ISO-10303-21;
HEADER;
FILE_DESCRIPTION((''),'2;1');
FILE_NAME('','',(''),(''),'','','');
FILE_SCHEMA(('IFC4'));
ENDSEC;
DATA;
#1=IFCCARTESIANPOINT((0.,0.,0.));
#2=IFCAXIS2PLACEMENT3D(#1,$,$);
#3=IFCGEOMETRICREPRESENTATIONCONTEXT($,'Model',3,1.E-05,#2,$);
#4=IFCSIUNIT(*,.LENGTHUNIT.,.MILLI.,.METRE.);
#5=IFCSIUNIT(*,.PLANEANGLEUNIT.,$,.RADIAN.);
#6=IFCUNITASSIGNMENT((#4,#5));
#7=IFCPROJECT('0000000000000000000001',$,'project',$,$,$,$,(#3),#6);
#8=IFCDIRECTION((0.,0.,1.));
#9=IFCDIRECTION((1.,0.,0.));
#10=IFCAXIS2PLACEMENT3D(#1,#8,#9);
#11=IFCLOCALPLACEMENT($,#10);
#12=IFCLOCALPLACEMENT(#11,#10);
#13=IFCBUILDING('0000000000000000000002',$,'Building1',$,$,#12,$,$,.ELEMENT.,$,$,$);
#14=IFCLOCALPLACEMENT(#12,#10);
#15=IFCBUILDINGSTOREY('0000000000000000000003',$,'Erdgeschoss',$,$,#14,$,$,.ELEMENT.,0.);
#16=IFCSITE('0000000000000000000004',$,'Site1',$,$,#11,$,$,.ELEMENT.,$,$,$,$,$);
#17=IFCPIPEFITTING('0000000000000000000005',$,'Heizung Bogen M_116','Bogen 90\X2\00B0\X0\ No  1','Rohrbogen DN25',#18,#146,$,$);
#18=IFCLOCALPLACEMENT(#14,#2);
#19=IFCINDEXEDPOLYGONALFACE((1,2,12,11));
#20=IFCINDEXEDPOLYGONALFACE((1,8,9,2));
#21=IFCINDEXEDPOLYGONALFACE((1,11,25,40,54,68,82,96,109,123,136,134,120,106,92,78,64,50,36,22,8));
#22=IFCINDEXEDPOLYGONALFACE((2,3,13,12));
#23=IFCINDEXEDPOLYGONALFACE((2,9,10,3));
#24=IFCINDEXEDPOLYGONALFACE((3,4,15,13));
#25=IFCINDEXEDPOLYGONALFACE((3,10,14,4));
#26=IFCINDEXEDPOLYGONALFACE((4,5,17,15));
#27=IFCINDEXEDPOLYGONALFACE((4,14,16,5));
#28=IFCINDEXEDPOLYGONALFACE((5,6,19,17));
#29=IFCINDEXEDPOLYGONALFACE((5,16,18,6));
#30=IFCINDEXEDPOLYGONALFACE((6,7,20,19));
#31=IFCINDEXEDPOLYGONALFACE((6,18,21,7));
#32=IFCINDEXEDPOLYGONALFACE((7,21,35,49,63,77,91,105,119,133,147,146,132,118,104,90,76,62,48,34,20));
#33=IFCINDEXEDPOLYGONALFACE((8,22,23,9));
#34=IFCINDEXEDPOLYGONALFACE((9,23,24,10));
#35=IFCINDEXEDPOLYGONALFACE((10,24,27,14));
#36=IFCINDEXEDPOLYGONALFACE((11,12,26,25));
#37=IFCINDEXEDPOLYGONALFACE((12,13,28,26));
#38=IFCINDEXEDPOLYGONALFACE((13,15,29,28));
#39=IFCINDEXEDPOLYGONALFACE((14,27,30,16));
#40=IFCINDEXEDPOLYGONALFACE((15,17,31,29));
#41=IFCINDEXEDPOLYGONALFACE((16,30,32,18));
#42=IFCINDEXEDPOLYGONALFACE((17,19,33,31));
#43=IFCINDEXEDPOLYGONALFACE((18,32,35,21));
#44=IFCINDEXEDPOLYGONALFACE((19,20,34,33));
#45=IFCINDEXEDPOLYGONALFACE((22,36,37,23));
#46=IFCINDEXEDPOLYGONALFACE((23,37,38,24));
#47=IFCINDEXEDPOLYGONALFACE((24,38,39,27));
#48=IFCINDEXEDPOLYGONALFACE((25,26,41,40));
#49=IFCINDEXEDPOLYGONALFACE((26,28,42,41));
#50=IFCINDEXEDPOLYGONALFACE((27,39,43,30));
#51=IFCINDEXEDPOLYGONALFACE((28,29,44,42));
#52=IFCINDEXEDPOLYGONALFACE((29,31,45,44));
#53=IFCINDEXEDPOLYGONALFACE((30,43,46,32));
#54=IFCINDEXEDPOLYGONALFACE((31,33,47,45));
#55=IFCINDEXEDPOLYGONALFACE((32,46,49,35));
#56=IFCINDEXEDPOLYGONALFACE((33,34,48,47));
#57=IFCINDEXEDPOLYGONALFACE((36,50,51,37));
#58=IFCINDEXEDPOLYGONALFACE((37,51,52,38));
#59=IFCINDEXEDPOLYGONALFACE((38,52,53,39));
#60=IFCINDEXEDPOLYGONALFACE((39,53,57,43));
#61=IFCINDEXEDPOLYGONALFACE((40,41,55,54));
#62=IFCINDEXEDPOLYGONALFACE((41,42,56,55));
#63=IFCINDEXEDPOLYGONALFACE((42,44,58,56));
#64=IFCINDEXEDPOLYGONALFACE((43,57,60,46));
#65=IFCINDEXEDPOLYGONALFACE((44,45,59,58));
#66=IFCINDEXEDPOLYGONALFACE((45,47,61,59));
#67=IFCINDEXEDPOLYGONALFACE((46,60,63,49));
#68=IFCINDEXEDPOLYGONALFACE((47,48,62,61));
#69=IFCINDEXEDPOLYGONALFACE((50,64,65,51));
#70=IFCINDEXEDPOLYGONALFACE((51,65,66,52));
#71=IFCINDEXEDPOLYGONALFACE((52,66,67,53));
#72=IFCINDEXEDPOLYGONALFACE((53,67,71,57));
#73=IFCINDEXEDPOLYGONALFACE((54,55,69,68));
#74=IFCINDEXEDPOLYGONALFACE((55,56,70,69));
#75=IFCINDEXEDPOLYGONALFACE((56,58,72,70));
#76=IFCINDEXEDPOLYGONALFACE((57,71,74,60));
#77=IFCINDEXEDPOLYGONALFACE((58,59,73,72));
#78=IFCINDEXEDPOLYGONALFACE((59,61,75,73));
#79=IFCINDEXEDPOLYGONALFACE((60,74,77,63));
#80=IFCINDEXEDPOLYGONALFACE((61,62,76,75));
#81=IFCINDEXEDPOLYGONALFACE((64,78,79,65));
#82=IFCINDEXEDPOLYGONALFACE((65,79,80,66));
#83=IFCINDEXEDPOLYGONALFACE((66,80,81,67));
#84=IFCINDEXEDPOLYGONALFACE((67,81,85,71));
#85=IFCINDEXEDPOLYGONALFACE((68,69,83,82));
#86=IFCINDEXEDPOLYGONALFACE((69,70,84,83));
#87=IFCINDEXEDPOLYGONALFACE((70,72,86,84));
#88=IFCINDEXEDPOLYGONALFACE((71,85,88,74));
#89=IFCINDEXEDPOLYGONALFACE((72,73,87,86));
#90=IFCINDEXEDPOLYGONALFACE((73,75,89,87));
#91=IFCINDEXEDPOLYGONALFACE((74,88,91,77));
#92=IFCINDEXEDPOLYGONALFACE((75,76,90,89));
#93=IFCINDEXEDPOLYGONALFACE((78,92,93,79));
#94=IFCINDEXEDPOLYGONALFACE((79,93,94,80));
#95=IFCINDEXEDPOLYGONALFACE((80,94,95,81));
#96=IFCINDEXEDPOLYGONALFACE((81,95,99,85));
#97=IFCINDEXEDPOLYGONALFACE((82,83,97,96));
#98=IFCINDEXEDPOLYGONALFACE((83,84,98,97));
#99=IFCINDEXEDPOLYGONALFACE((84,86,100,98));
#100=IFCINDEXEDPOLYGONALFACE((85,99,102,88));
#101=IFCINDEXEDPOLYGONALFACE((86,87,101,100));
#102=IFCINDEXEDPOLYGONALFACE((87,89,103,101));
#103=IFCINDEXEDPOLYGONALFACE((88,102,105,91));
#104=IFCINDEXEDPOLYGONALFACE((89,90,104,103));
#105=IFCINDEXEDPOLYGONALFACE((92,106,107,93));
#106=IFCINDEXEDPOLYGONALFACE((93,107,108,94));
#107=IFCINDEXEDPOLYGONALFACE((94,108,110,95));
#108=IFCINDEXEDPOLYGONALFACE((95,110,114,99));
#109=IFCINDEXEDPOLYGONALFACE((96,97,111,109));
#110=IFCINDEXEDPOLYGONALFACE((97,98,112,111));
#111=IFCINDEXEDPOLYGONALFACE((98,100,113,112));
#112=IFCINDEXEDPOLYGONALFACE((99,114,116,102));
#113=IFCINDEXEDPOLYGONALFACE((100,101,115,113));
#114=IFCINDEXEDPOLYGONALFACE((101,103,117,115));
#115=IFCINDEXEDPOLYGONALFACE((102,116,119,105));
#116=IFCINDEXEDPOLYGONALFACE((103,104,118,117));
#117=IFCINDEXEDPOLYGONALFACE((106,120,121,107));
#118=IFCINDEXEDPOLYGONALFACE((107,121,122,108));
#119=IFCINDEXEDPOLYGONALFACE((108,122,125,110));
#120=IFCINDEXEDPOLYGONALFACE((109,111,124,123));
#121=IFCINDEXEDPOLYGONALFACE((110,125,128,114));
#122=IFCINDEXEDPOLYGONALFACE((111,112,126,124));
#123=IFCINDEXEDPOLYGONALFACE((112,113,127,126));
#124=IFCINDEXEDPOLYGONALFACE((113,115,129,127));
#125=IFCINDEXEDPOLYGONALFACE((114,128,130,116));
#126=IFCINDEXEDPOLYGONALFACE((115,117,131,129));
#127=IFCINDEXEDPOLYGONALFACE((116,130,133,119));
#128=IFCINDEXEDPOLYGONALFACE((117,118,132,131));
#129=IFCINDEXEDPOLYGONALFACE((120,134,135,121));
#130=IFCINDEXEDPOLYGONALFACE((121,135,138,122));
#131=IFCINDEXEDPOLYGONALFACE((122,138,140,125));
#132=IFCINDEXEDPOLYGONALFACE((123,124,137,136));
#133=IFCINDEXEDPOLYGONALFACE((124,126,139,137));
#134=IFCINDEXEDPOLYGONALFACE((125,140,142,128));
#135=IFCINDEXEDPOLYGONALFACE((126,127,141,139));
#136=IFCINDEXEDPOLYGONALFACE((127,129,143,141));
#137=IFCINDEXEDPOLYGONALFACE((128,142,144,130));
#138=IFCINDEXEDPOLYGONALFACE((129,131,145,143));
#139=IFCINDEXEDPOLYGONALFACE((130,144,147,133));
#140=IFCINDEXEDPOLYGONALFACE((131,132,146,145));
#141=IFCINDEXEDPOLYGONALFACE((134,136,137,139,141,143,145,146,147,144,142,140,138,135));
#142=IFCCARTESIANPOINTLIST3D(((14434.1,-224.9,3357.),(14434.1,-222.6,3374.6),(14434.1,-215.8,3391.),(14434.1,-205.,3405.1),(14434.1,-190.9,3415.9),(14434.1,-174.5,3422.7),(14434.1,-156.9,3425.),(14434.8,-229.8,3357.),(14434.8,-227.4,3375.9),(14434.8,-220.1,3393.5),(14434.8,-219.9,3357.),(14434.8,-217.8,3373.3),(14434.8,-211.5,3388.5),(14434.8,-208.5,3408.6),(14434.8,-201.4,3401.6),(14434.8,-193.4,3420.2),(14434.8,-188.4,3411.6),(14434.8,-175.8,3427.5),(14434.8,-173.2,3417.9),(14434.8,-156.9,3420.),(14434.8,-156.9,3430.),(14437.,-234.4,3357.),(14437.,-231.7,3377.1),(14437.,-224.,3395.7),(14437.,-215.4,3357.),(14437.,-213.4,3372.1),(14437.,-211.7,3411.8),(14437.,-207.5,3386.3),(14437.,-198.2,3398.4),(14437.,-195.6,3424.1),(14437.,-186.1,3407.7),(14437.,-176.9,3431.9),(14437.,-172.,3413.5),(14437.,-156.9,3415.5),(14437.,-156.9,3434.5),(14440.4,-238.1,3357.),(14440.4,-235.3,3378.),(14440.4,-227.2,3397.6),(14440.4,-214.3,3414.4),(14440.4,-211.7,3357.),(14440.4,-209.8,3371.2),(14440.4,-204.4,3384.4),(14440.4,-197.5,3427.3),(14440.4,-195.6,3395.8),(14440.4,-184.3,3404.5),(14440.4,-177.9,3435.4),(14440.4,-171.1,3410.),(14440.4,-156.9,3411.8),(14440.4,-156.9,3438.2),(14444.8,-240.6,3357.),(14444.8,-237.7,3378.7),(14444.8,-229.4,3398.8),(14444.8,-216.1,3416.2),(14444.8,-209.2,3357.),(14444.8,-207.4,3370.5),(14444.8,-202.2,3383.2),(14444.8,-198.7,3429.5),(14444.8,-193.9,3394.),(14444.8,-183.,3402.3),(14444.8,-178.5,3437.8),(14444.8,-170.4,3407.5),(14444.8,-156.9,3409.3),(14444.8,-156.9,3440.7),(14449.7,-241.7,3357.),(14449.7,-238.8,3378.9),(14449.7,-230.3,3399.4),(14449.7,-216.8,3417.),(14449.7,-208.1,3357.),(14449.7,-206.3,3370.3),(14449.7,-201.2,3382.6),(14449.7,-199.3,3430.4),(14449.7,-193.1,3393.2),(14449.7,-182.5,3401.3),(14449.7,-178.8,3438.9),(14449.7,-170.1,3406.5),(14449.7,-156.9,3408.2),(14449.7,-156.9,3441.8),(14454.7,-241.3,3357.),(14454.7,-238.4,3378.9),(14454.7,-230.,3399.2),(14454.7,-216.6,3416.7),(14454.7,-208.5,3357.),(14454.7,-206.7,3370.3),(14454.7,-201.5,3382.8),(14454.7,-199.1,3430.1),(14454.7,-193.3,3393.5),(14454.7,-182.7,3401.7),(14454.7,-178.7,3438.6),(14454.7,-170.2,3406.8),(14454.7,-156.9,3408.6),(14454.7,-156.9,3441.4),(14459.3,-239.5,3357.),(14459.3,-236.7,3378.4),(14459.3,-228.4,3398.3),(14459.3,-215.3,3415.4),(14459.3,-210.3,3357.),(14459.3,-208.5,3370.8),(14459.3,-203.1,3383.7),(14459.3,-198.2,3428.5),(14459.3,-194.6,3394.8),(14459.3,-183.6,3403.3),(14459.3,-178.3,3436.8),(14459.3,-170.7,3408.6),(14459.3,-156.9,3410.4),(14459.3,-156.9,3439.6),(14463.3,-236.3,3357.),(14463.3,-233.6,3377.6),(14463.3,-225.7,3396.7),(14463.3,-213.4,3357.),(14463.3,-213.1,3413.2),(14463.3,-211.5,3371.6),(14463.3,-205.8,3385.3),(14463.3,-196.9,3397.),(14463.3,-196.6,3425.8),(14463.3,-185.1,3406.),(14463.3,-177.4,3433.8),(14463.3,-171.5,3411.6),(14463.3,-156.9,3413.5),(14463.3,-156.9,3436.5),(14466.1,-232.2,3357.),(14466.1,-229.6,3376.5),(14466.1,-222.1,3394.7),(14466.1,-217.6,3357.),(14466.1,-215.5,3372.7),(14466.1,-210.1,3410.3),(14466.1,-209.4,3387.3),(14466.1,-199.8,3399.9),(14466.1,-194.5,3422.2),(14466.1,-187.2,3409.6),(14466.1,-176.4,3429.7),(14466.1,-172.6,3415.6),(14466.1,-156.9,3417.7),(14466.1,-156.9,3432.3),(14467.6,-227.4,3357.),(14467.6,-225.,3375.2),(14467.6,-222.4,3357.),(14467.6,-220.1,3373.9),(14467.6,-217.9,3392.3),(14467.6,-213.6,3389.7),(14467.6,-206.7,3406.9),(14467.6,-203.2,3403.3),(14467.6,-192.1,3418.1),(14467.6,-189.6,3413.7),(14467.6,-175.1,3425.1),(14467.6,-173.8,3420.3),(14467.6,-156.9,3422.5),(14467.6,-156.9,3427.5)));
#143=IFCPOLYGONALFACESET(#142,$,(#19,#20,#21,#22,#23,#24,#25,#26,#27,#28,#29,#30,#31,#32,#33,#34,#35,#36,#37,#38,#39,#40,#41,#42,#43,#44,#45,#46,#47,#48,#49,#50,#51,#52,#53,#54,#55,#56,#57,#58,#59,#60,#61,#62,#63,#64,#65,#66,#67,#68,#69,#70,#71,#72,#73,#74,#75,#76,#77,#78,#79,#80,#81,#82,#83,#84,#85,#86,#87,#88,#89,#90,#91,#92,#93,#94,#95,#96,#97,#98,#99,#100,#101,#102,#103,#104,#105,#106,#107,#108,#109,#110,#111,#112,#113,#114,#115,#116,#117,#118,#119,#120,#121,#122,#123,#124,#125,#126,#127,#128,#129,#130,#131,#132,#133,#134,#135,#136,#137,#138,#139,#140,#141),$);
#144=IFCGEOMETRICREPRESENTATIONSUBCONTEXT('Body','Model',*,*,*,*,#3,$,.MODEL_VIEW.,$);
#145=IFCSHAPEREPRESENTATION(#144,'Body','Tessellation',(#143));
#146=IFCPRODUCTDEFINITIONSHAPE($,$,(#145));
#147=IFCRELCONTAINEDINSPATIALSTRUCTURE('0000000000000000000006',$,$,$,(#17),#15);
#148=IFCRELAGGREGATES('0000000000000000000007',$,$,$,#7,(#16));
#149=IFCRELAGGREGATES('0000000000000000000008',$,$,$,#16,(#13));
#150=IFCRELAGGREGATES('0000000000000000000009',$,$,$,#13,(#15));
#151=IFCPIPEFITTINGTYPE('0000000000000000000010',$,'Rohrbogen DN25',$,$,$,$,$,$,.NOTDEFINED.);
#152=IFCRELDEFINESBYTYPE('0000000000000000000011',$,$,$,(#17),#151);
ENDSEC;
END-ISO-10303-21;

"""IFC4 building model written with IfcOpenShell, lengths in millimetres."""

from ifc_helpers import new_model, entity, si_unit, frame, origin, origin_with_axes, place, context, subcontext, project, spatial, shape, source, transform, mapped, type_object, element, save


model = new_model("IFC4")

# Units and contexts
model_context = context("Model", 3, precision=1e-05, world=origin())
body_context = subcontext(model_context, "Body", "Model", "MODEL_VIEW")
ifc_project = project(units=[si_unit("LENGTHUNIT", "METRE", prefix="MILLI"), si_unit("PLANEANGLEUNIT", "RADIAN")], contexts=[model_context])

# Site, building, storey
site_placement = place(None, origin_with_axes())
site = spatial("IfcSite", under=ifc_project, at=site_placement, Name="Site1", CompositionType="ELEMENT")
building_placement = place(site_placement, origin_with_axes())
building = spatial("IfcBuilding", under=site, at=building_placement, Name="Building1", CompositionType="ELEMENT")
storey_placement = place(building_placement, origin_with_axes())
storey = spatial("IfcBuildingStorey", under=building, at=storey_placement, Name="Erdgeschoss", CompositionType="ELEMENT", Elevation=0.0)

# Pipe fitting
pipe_fitting_type = type_object("IfcPipeFittingType", Name="Rohrbogen DN25", PredefinedType="NOTDEFINED")
shared_shape_1 = source(origin_with_axes(), body_context, "Body", "SolidModel", [
    entity("IfcRevolvedAreaSolid", entity("IfcCircleProfileDef", "AREA", None, entity("IfcAxis2Placement2D", entity("IfcCartesianPoint", [0.0, 0.0]), entity("IfcDirection", [1.0, 0.0])), 16.9), entity("IfcAxis2Placement3D", entity("IfcCartesianPoint", [-42.4, 0.0, 25.6]), entity("IfcDirection", [1.0, 0.0, 0.0]), entity("IfcDirection", [0.0, -1.0, 0.0])), entity("IfcAxis1Placement", entity("IfcCartesianPoint", [0.0, 68.0, 0.0]), entity("IfcDirection", [-1.0, 0.0, 0.0])), 1.570796),
])
pipe_fitting_1_placement = place(storey_placement, frame((14450.9, -199.3, 3399.4), z_axis=(0.0, 0.0, 1.0), x_axis=(1.0, 0.0, 0.0)))
element("IfcPipeFitting", 1, at=pipe_fitting_1_placement, inside=storey, type_object=pipe_fitting_type, Name="Heizung Bogen M_116", Description="Bogen 90° No  1", ObjectType="Rohrbogen DN25", shapes=[
    shape(body_context, "Body", "MappedRepresentation", [mapped(shared_shape_1, transform((0.0, 0.0, 0.0), x_axis=(0.0, -1.0, 0.0), y_axis=(1.0, 0.0, 0.0), z_axis=(0.0, 0.0, 1.0), scale=1.0))]),
    shape(body_context, "Body", "MappedRepresentation", [mapped(shared_shape_1, transform((0.0, 0.0, 0.0), x_axis=(0.0, -1.0, 0.0), y_axis=(1.0, 0.0, 0.0), z_axis=(0.0, 0.0, 1.0), scale=1.0))]),
])

save(model, "model.ifc")
